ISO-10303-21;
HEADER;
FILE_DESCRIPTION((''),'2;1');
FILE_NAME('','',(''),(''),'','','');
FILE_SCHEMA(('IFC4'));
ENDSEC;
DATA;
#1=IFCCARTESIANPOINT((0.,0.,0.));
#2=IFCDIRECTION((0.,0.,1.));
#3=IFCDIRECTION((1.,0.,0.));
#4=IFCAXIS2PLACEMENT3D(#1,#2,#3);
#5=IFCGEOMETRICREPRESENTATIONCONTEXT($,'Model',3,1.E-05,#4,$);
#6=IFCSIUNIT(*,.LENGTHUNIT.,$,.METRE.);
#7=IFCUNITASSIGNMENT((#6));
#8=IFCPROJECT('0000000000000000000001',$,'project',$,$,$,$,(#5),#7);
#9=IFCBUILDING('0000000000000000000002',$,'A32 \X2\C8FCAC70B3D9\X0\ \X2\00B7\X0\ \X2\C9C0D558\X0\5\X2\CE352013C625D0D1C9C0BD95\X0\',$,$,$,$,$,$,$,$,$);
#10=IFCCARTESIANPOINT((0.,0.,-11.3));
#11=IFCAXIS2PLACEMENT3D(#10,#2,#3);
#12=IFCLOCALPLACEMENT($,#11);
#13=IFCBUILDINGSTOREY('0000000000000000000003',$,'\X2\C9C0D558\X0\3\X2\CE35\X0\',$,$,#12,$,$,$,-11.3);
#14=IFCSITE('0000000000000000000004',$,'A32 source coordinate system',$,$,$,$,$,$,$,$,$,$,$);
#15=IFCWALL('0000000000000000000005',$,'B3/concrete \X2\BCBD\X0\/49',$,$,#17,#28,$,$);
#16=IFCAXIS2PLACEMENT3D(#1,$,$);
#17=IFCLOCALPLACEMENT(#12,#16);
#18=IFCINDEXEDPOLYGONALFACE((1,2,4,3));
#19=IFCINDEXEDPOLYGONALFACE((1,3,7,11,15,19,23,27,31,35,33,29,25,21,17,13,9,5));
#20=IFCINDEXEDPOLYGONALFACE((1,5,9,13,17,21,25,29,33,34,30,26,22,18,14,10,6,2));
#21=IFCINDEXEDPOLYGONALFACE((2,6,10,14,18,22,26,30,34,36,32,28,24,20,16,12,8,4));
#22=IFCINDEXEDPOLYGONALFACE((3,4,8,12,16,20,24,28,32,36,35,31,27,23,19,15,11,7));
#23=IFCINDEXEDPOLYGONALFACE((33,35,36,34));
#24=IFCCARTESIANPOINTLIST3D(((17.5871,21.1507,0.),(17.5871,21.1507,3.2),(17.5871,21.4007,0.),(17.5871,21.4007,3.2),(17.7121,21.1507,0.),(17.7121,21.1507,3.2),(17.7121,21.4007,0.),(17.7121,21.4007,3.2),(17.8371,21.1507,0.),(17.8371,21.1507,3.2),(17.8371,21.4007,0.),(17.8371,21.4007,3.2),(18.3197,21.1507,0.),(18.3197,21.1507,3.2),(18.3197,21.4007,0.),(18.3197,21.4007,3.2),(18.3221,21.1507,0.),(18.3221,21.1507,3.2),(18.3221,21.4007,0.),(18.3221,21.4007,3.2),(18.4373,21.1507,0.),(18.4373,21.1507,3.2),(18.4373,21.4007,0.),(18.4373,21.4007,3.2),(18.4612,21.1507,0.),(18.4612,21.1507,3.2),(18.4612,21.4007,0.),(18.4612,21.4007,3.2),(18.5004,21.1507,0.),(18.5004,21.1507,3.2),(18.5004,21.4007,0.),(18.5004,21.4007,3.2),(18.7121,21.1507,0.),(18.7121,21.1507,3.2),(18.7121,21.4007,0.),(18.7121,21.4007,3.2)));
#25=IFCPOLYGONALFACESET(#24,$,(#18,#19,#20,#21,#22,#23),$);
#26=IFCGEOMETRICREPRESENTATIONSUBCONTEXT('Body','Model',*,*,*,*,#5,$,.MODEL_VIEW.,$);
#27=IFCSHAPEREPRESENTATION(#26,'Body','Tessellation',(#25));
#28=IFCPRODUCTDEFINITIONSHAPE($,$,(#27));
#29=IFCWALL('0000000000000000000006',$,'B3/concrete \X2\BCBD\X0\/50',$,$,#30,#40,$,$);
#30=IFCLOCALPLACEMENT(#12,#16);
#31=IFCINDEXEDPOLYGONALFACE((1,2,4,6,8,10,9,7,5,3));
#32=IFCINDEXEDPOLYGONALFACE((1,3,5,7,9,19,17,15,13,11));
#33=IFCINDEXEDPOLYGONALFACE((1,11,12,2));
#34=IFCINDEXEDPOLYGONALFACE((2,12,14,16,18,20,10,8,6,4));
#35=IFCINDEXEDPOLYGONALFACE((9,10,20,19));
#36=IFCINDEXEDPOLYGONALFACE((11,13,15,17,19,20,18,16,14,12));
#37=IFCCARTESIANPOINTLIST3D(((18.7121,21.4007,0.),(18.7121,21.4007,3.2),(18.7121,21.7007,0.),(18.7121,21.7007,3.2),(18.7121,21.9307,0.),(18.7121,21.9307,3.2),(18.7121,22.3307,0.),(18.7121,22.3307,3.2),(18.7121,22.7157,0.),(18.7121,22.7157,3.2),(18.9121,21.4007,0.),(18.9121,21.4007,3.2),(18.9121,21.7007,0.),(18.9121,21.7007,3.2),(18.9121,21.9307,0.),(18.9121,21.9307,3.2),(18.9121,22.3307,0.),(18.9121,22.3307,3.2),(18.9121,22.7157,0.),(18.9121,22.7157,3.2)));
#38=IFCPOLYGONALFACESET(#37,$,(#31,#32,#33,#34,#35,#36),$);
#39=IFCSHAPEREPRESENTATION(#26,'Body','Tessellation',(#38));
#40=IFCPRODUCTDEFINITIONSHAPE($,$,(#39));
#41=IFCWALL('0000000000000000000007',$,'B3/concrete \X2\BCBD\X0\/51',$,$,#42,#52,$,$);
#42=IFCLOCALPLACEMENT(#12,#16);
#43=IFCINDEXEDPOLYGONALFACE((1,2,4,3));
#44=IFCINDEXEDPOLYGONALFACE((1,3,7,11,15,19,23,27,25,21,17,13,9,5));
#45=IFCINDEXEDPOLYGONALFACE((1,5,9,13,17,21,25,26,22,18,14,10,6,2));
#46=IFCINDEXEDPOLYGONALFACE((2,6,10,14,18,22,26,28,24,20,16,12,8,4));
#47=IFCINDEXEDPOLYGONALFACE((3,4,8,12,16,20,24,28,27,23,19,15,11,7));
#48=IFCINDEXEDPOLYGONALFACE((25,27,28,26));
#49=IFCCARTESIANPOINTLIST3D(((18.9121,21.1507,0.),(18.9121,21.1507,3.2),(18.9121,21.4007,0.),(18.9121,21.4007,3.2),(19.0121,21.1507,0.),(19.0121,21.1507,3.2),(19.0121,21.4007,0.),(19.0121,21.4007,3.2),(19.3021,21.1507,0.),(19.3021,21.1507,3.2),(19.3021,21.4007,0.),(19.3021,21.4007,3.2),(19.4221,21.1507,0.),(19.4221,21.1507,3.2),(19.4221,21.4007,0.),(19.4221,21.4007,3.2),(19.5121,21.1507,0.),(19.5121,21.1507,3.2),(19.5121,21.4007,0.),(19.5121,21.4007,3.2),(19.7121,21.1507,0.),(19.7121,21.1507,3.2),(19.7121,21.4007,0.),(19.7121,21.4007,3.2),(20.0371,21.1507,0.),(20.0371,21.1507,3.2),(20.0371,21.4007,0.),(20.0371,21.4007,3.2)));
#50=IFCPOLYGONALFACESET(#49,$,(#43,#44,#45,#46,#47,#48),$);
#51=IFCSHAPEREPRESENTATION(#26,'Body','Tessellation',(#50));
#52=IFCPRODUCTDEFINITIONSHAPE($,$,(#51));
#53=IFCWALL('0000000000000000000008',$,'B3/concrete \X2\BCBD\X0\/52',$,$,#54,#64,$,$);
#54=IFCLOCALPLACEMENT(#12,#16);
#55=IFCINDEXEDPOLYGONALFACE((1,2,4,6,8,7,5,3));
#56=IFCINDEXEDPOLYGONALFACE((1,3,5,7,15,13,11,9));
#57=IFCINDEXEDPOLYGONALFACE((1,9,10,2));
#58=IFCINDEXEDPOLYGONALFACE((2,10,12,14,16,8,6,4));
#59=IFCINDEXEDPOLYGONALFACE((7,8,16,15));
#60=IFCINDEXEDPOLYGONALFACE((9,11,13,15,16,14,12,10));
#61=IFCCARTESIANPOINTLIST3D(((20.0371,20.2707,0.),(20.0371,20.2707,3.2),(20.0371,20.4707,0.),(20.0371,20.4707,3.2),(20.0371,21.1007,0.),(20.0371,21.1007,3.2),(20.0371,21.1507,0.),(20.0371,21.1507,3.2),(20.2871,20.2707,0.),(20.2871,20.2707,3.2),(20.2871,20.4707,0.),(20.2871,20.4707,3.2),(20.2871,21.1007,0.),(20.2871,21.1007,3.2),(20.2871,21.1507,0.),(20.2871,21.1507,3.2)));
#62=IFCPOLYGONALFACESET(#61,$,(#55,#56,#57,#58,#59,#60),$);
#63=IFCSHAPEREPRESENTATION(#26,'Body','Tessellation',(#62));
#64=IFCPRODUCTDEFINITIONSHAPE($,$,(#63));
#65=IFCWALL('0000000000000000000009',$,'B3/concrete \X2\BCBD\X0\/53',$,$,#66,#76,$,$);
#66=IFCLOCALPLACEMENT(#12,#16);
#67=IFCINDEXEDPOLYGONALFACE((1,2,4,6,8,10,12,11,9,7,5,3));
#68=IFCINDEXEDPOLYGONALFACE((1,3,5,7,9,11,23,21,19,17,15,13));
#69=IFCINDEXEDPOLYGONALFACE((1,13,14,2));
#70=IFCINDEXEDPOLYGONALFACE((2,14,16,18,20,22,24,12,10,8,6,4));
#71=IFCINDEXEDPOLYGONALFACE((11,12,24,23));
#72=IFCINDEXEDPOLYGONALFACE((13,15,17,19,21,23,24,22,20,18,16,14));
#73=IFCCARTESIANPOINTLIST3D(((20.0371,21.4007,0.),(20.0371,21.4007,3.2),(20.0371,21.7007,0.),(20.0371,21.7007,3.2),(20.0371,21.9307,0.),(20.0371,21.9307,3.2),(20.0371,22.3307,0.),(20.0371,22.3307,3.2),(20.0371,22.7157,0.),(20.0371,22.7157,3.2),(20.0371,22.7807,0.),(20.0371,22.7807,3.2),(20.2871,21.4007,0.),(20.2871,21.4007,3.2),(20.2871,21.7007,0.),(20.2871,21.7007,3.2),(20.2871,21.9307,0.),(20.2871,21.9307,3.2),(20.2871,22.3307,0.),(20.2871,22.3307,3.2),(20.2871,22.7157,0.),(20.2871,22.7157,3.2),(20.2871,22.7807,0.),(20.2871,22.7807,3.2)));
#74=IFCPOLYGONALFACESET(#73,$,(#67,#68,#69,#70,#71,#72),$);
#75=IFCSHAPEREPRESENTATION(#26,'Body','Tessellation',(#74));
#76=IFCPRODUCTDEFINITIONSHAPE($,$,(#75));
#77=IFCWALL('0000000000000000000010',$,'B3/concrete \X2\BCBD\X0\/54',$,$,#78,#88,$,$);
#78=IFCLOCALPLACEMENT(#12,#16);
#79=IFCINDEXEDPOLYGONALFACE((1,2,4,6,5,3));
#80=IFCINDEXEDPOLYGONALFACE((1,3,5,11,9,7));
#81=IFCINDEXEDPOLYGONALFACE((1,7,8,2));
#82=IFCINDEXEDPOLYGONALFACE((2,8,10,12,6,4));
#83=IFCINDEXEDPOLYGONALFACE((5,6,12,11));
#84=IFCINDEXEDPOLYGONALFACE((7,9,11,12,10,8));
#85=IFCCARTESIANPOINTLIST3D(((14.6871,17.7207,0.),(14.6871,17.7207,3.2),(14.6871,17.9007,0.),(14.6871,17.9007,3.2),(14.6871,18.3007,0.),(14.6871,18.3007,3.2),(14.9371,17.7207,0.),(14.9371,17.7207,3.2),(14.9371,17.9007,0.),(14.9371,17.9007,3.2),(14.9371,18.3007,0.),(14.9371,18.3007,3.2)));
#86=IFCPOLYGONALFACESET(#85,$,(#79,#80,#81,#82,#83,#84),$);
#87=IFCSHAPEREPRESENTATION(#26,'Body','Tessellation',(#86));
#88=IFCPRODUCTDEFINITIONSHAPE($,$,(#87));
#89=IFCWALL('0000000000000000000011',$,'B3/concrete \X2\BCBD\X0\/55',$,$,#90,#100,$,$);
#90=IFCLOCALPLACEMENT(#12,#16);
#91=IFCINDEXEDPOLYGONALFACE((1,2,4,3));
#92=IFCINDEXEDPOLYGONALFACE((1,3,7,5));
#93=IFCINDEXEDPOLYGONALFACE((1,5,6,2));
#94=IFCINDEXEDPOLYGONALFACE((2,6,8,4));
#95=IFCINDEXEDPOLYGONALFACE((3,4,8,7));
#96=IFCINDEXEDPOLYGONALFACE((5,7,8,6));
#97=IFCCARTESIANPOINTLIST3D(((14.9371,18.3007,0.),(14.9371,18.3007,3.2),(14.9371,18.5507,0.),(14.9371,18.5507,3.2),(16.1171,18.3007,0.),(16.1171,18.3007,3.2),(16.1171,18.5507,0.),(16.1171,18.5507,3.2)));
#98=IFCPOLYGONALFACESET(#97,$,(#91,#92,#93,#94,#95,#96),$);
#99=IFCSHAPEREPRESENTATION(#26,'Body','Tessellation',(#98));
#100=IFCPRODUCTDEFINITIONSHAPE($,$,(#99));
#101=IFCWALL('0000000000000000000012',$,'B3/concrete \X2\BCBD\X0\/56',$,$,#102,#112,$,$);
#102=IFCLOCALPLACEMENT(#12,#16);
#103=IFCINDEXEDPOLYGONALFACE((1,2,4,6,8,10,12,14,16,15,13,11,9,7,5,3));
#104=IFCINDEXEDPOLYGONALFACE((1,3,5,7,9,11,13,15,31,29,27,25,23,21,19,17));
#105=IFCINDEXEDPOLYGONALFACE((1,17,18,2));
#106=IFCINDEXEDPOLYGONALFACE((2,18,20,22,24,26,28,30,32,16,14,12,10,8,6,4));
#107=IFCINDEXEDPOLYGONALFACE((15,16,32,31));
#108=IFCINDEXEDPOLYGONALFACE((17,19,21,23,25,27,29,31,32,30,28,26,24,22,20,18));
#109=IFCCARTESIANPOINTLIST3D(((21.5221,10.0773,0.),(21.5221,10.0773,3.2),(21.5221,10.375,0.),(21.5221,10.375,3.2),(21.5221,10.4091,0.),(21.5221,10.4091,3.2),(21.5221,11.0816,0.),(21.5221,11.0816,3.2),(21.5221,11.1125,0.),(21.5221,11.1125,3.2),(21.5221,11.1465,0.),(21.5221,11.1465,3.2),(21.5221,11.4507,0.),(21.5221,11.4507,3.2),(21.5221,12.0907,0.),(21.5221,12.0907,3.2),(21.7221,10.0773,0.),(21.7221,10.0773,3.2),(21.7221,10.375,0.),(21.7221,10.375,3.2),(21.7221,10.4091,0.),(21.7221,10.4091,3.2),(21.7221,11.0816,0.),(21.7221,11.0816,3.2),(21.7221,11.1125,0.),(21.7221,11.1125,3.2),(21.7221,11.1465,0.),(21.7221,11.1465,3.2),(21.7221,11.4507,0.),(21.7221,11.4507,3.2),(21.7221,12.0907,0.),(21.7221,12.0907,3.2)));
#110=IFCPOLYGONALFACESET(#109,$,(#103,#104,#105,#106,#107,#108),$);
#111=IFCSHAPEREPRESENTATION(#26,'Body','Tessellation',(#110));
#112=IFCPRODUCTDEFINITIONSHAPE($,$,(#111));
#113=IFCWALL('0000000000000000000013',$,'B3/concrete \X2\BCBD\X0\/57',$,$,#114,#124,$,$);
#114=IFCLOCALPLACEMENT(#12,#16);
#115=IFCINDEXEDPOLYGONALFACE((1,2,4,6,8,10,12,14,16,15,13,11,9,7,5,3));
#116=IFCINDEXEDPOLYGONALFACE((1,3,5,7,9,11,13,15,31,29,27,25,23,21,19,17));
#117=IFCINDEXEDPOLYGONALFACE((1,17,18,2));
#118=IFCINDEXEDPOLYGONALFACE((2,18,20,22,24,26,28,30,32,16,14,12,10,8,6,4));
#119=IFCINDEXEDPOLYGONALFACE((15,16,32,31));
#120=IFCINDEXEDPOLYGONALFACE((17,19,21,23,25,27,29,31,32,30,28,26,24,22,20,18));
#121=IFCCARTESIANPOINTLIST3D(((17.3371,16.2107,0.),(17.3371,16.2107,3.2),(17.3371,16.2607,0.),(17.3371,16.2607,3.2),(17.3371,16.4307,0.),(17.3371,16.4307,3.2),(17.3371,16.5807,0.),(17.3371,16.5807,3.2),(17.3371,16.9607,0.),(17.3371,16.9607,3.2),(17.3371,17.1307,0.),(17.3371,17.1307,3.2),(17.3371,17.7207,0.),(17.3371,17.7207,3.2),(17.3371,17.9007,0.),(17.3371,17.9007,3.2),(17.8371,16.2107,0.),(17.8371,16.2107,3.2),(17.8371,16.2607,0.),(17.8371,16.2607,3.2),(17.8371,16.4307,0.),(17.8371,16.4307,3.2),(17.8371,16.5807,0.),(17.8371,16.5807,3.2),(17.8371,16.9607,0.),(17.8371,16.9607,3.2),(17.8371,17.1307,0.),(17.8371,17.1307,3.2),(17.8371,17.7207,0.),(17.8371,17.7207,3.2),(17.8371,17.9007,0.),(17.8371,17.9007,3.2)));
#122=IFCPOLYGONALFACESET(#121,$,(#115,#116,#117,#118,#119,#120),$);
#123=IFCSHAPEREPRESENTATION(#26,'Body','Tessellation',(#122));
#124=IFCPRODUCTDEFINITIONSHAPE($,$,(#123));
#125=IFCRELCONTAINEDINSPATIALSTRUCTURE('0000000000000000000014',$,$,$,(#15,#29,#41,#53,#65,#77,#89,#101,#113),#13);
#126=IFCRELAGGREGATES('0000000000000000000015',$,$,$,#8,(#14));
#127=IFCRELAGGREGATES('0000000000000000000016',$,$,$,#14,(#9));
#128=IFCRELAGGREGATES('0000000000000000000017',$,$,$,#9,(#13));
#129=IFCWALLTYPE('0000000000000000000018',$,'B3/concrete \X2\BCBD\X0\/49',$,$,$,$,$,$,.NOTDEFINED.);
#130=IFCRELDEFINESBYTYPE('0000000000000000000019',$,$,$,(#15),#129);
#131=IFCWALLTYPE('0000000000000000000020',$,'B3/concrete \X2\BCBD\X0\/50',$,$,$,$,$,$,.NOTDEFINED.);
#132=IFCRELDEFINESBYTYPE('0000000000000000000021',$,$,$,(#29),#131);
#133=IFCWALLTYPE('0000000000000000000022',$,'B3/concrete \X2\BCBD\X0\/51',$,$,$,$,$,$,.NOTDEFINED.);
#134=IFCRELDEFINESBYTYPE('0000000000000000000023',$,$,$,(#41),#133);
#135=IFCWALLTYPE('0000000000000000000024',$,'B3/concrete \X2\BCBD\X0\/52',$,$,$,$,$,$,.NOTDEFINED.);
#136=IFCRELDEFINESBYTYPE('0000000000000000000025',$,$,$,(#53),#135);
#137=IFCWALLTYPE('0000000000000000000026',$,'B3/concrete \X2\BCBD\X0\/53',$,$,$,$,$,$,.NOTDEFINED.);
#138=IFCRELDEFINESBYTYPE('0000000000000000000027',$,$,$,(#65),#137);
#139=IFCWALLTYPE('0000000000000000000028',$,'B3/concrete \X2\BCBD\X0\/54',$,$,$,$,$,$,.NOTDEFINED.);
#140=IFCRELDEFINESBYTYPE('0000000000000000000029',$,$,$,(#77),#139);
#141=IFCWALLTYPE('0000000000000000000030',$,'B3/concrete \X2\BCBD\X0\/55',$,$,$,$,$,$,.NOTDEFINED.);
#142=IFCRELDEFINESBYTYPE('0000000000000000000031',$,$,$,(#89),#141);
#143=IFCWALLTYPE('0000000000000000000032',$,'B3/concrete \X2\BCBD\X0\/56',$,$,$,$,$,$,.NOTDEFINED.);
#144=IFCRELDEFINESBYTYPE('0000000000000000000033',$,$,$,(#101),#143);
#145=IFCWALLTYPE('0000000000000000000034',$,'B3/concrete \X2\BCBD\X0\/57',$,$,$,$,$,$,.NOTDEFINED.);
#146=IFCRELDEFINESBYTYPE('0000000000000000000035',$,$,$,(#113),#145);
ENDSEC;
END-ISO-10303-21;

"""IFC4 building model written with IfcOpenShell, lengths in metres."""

from ifc_helpers import new_model, si_unit, frame, origin, origin_with_axes, place, context, subcontext, project, spatial, polyline, outline, extrude, source, transform, mapped, type_object, type_shapes, element, save


model = new_model("IFC4")

# Units and contexts
model_context = context("Model", 3, precision=1e-05, world=origin_with_axes())
body_context = subcontext(model_context, "Body", "Model", "MODEL_VIEW")
ifc_project = project(units=[si_unit("LENGTHUNIT", "METRE")], contexts=[model_context])

# Site, building, storey
site = spatial("IfcSite", under=ifc_project, Name="A32 source coordinate system")
building = spatial("IfcBuilding", under=site, Name="A32 주거동 · 지하5층–옥탑지붕")
storey_placement = place(None, frame((0.0, 0.0, -11.3), z_axis=(0.0, 0.0, 1.0), x_axis=(1.0, 0.0, 0.0)))
storey = spatial("IfcBuildingStorey", under=building, at=storey_placement, Name="지하3층", Elevation=-11.3)

# Walls
wall_type_1 = type_object("IfcWallType", Name="B3/concrete 벽/49", PredefinedType="NOTDEFINED")
shared_shape_1 = source(origin(), body_context, "Body", "SweptSolid", [
    extrude(outline(polyline([(17.8371, 21.4007), (18.3197, 21.4007), (18.3221, 21.4007), (18.4373, 21.4007), (18.4612, 21.4007), (18.5004, 21.4007), (18.7121, 21.4007), (18.7121, 21.1507), (18.5004, 21.1507), (18.4612, 21.1507), (18.4373, 21.1507), (18.3221, 21.1507), (18.3197, 21.1507), (17.8371, 21.1507), (17.7121, 21.1507), (17.5871, 21.1507), (17.5871, 21.4007), (17.7121, 21.4007), (17.8371, 21.4007)])), origin(), (0.0, 0.0, 1.0), 3.2),
])
type_shapes(wall_type_1, [shared_shape_1])
wall_1_placement = place(storey_placement, origin_with_axes())
element("IfcWall", 1, at=wall_1_placement, inside=storey, type_object=wall_type_1, Name="B3/concrete 벽/49", context=body_context, shape_type="MappedRepresentation", body=[
    mapped(shared_shape_1, transform((0.0, 0.0, 0.0), scale=1.0)),
])
wall_type_2 = type_object("IfcWallType", Name="B3/concrete 벽/50", PredefinedType="NOTDEFINED")
shared_shape_2 = source(origin(), body_context, "Body", "SweptSolid", [
    extrude(outline(polyline([(18.7121, 22.3307), (18.7121, 22.7157), (18.9121, 22.7157), (18.9121, 22.3307), (18.9121, 21.9307), (18.9121, 21.7007), (18.9121, 21.4007), (18.7121, 21.4007), (18.7121, 21.7007), (18.7121, 21.9307), (18.7121, 22.3307)])), origin(), (0.0, 0.0, 1.0), 3.2),
])
type_shapes(wall_type_2, [shared_shape_2])
wall_2_placement = place(storey_placement, origin_with_axes())
element("IfcWall", 2, at=wall_2_placement, inside=storey, type_object=wall_type_2, Name="B3/concrete 벽/50", context=body_context, shape_type="MappedRepresentation", body=[
    mapped(shared_shape_2, transform((0.0, 0.0, 0.0), scale=1.0)),
])
wall_type_3 = type_object("IfcWallType", Name="B3/concrete 벽/51", PredefinedType="NOTDEFINED")
shared_shape_3 = source(origin(), body_context, "Body", "SweptSolid", [
    extrude(outline(polyline([(19.4221, 21.4007), (19.5121, 21.4007), (19.7121, 21.4007), (20.0371, 21.4007), (20.0371, 21.1507), (19.7121, 21.1507), (19.5121, 21.1507), (19.4221, 21.1507), (19.3021, 21.1507), (19.0121, 21.1507), (18.9121, 21.1507), (18.9121, 21.4007), (19.0121, 21.4007), (19.3021, 21.4007), (19.4221, 21.4007)])), origin(), (0.0, 0.0, 1.0), 3.2),
])
type_shapes(wall_type_3, [shared_shape_3])
wall_3_placement = place(storey_placement, origin_with_axes())
element("IfcWall", 3, at=wall_3_placement, inside=storey, type_object=wall_type_3, Name="B3/concrete 벽/51", context=body_context, shape_type="MappedRepresentation", body=[
    mapped(shared_shape_3, transform((0.0, 0.0, 0.0), scale=1.0)),
])
wall_type_4 = type_object("IfcWallType", Name="B3/concrete 벽/52", PredefinedType="NOTDEFINED")
shared_shape_4 = source(origin(), body_context, "Body", "SweptSolid", [
    extrude(outline(polyline([(20.2871, 20.4707), (20.2871, 20.2707), (20.0371, 20.2707), (20.0371, 20.4707), (20.0371, 21.1007), (20.0371, 21.1507), (20.2871, 21.1507), (20.2871, 21.1007), (20.2871, 20.4707)])), origin(), (0.0, 0.0, 1.0), 3.2),
])
type_shapes(wall_type_4, [shared_shape_4])
wall_4_placement = place(storey_placement, origin_with_axes())
element("IfcWall", 4, at=wall_4_placement, inside=storey, type_object=wall_type_4, Name="B3/concrete 벽/52", context=body_context, shape_type="MappedRepresentation", body=[
    mapped(shared_shape_4, transform((0.0, 0.0, 0.0), scale=1.0)),
])
wall_type_5 = type_object("IfcWallType", Name="B3/concrete 벽/53", PredefinedType="NOTDEFINED")
shared_shape_5 = source(origin(), body_context, "Body", "SweptSolid", [
    extrude(outline(polyline([(20.0371, 22.3307), (20.0371, 22.7157), (20.0371, 22.7807), (20.2871, 22.7807), (20.2871, 22.7157), (20.2871, 22.3307), (20.2871, 21.9307), (20.2871, 21.7007), (20.2871, 21.4007), (20.0371, 21.4007), (20.0371, 21.7007), (20.0371, 21.9307), (20.0371, 22.3307)])), origin(), (0.0, 0.0, 1.0), 3.2),
])
type_shapes(wall_type_5, [shared_shape_5])
wall_5_placement = place(storey_placement, origin_with_axes())
element("IfcWall", 5, at=wall_5_placement, inside=storey, type_object=wall_type_5, Name="B3/concrete 벽/53", context=body_context, shape_type="MappedRepresentation", body=[
    mapped(shared_shape_5, transform((0.0, 0.0, 0.0), scale=1.0)),
])
wall_type_6 = type_object("IfcWallType", Name="B3/concrete 벽/54", PredefinedType="NOTDEFINED")
shared_shape_6 = source(origin(), body_context, "Body", "SweptSolid", [
    extrude(outline(polyline([(14.9371, 17.7207), (14.6871, 17.7207), (14.6871, 17.9007), (14.6871, 18.3007), (14.9371, 18.3007), (14.9371, 17.9007), (14.9371, 17.7207)])), origin(), (0.0, 0.0, 1.0), 3.2),
])
type_shapes(wall_type_6, [shared_shape_6])
wall_6_placement = place(storey_placement, origin_with_axes())
element("IfcWall", 6, at=wall_6_placement, inside=storey, type_object=wall_type_6, Name="B3/concrete 벽/54", context=body_context, shape_type="MappedRepresentation", body=[
    mapped(shared_shape_6, transform((0.0, 0.0, 0.0), scale=1.0)),
])
wall_type_7 = type_object("IfcWallType", Name="B3/concrete 벽/55", PredefinedType="NOTDEFINED")
shared_shape_7 = source(origin(), body_context, "Body", "SweptSolid", [
    extrude(outline(polyline([(16.1171, 18.3007), (14.9371, 18.3007), (14.9371, 18.5507), (16.1171, 18.5507), (16.1171, 18.3007)])), origin(), (0.0, 0.0, 1.0), 3.2),
])
type_shapes(wall_type_7, [shared_shape_7])
wall_7_placement = place(storey_placement, origin_with_axes())
element("IfcWall", 7, at=wall_7_placement, inside=storey, type_object=wall_type_7, Name="B3/concrete 벽/55", context=body_context, shape_type="MappedRepresentation", body=[
    mapped(shared_shape_7, transform((0.0, 0.0, 0.0), scale=1.0)),
])
wall_type_8 = type_object("IfcWallType", Name="B3/concrete 벽/56", PredefinedType="NOTDEFINED")
shared_shape_8 = source(origin(), body_context, "Body", "SweptSolid", [
    extrude(outline(polyline([(21.7221, 11.4507), (21.7221, 11.1465), (21.7221, 11.1125), (21.7221, 11.0816), (21.7221, 10.4091), (21.7221, 10.375), (21.7221, 10.0773), (21.5221, 10.0773), (21.5221, 10.375), (21.5221, 10.4091), (21.5221, 11.0816), (21.5221, 11.1125), (21.5221, 11.1465), (21.5221, 11.4507), (21.5221, 12.0907), (21.7221, 12.0907), (21.7221, 11.4507)])), origin(), (0.0, 0.0, 1.0), 3.2),
])
type_shapes(wall_type_8, [shared_shape_8])
wall_8_placement = place(storey_placement, origin_with_axes())
element("IfcWall", 8, at=wall_8_placement, inside=storey, type_object=wall_type_8, Name="B3/concrete 벽/56", context=body_context, shape_type="MappedRepresentation", body=[
    mapped(shared_shape_8, transform((0.0, 0.0, 0.0), scale=1.0)),
])
wall_type_9 = type_object("IfcWallType", Name="B3/concrete 벽/57", PredefinedType="NOTDEFINED")
shared_shape_9 = source(origin(), body_context, "Body", "SweptSolid", [
    extrude(outline(polyline([(17.8371, 17.1307), (17.8371, 16.9607), (17.8371, 16.5807), (17.8371, 16.4307), (17.8371, 16.2607), (17.8371, 16.2107), (17.3371, 16.2107), (17.3371, 16.2607), (17.3371, 16.4307), (17.3371, 16.5807), (17.3371, 16.9607), (17.3371, 17.1307), (17.3371, 17.7207), (17.3371, 17.9007), (17.8371, 17.9007), (17.8371, 17.7207), (17.8371, 17.1307)])), origin(), (0.0, 0.0, 1.0), 3.2),
])
type_shapes(wall_type_9, [shared_shape_9])
wall_9_placement = place(storey_placement, origin_with_axes())
element("IfcWall", 9, at=wall_9_placement, inside=storey, type_object=wall_type_9, Name="B3/concrete 벽/57", context=body_context, shape_type="MappedRepresentation", body=[
    mapped(shared_shape_9, transform((0.0, 0.0, 0.0), scale=1.0)),
])

save(model, "model.ifc")
